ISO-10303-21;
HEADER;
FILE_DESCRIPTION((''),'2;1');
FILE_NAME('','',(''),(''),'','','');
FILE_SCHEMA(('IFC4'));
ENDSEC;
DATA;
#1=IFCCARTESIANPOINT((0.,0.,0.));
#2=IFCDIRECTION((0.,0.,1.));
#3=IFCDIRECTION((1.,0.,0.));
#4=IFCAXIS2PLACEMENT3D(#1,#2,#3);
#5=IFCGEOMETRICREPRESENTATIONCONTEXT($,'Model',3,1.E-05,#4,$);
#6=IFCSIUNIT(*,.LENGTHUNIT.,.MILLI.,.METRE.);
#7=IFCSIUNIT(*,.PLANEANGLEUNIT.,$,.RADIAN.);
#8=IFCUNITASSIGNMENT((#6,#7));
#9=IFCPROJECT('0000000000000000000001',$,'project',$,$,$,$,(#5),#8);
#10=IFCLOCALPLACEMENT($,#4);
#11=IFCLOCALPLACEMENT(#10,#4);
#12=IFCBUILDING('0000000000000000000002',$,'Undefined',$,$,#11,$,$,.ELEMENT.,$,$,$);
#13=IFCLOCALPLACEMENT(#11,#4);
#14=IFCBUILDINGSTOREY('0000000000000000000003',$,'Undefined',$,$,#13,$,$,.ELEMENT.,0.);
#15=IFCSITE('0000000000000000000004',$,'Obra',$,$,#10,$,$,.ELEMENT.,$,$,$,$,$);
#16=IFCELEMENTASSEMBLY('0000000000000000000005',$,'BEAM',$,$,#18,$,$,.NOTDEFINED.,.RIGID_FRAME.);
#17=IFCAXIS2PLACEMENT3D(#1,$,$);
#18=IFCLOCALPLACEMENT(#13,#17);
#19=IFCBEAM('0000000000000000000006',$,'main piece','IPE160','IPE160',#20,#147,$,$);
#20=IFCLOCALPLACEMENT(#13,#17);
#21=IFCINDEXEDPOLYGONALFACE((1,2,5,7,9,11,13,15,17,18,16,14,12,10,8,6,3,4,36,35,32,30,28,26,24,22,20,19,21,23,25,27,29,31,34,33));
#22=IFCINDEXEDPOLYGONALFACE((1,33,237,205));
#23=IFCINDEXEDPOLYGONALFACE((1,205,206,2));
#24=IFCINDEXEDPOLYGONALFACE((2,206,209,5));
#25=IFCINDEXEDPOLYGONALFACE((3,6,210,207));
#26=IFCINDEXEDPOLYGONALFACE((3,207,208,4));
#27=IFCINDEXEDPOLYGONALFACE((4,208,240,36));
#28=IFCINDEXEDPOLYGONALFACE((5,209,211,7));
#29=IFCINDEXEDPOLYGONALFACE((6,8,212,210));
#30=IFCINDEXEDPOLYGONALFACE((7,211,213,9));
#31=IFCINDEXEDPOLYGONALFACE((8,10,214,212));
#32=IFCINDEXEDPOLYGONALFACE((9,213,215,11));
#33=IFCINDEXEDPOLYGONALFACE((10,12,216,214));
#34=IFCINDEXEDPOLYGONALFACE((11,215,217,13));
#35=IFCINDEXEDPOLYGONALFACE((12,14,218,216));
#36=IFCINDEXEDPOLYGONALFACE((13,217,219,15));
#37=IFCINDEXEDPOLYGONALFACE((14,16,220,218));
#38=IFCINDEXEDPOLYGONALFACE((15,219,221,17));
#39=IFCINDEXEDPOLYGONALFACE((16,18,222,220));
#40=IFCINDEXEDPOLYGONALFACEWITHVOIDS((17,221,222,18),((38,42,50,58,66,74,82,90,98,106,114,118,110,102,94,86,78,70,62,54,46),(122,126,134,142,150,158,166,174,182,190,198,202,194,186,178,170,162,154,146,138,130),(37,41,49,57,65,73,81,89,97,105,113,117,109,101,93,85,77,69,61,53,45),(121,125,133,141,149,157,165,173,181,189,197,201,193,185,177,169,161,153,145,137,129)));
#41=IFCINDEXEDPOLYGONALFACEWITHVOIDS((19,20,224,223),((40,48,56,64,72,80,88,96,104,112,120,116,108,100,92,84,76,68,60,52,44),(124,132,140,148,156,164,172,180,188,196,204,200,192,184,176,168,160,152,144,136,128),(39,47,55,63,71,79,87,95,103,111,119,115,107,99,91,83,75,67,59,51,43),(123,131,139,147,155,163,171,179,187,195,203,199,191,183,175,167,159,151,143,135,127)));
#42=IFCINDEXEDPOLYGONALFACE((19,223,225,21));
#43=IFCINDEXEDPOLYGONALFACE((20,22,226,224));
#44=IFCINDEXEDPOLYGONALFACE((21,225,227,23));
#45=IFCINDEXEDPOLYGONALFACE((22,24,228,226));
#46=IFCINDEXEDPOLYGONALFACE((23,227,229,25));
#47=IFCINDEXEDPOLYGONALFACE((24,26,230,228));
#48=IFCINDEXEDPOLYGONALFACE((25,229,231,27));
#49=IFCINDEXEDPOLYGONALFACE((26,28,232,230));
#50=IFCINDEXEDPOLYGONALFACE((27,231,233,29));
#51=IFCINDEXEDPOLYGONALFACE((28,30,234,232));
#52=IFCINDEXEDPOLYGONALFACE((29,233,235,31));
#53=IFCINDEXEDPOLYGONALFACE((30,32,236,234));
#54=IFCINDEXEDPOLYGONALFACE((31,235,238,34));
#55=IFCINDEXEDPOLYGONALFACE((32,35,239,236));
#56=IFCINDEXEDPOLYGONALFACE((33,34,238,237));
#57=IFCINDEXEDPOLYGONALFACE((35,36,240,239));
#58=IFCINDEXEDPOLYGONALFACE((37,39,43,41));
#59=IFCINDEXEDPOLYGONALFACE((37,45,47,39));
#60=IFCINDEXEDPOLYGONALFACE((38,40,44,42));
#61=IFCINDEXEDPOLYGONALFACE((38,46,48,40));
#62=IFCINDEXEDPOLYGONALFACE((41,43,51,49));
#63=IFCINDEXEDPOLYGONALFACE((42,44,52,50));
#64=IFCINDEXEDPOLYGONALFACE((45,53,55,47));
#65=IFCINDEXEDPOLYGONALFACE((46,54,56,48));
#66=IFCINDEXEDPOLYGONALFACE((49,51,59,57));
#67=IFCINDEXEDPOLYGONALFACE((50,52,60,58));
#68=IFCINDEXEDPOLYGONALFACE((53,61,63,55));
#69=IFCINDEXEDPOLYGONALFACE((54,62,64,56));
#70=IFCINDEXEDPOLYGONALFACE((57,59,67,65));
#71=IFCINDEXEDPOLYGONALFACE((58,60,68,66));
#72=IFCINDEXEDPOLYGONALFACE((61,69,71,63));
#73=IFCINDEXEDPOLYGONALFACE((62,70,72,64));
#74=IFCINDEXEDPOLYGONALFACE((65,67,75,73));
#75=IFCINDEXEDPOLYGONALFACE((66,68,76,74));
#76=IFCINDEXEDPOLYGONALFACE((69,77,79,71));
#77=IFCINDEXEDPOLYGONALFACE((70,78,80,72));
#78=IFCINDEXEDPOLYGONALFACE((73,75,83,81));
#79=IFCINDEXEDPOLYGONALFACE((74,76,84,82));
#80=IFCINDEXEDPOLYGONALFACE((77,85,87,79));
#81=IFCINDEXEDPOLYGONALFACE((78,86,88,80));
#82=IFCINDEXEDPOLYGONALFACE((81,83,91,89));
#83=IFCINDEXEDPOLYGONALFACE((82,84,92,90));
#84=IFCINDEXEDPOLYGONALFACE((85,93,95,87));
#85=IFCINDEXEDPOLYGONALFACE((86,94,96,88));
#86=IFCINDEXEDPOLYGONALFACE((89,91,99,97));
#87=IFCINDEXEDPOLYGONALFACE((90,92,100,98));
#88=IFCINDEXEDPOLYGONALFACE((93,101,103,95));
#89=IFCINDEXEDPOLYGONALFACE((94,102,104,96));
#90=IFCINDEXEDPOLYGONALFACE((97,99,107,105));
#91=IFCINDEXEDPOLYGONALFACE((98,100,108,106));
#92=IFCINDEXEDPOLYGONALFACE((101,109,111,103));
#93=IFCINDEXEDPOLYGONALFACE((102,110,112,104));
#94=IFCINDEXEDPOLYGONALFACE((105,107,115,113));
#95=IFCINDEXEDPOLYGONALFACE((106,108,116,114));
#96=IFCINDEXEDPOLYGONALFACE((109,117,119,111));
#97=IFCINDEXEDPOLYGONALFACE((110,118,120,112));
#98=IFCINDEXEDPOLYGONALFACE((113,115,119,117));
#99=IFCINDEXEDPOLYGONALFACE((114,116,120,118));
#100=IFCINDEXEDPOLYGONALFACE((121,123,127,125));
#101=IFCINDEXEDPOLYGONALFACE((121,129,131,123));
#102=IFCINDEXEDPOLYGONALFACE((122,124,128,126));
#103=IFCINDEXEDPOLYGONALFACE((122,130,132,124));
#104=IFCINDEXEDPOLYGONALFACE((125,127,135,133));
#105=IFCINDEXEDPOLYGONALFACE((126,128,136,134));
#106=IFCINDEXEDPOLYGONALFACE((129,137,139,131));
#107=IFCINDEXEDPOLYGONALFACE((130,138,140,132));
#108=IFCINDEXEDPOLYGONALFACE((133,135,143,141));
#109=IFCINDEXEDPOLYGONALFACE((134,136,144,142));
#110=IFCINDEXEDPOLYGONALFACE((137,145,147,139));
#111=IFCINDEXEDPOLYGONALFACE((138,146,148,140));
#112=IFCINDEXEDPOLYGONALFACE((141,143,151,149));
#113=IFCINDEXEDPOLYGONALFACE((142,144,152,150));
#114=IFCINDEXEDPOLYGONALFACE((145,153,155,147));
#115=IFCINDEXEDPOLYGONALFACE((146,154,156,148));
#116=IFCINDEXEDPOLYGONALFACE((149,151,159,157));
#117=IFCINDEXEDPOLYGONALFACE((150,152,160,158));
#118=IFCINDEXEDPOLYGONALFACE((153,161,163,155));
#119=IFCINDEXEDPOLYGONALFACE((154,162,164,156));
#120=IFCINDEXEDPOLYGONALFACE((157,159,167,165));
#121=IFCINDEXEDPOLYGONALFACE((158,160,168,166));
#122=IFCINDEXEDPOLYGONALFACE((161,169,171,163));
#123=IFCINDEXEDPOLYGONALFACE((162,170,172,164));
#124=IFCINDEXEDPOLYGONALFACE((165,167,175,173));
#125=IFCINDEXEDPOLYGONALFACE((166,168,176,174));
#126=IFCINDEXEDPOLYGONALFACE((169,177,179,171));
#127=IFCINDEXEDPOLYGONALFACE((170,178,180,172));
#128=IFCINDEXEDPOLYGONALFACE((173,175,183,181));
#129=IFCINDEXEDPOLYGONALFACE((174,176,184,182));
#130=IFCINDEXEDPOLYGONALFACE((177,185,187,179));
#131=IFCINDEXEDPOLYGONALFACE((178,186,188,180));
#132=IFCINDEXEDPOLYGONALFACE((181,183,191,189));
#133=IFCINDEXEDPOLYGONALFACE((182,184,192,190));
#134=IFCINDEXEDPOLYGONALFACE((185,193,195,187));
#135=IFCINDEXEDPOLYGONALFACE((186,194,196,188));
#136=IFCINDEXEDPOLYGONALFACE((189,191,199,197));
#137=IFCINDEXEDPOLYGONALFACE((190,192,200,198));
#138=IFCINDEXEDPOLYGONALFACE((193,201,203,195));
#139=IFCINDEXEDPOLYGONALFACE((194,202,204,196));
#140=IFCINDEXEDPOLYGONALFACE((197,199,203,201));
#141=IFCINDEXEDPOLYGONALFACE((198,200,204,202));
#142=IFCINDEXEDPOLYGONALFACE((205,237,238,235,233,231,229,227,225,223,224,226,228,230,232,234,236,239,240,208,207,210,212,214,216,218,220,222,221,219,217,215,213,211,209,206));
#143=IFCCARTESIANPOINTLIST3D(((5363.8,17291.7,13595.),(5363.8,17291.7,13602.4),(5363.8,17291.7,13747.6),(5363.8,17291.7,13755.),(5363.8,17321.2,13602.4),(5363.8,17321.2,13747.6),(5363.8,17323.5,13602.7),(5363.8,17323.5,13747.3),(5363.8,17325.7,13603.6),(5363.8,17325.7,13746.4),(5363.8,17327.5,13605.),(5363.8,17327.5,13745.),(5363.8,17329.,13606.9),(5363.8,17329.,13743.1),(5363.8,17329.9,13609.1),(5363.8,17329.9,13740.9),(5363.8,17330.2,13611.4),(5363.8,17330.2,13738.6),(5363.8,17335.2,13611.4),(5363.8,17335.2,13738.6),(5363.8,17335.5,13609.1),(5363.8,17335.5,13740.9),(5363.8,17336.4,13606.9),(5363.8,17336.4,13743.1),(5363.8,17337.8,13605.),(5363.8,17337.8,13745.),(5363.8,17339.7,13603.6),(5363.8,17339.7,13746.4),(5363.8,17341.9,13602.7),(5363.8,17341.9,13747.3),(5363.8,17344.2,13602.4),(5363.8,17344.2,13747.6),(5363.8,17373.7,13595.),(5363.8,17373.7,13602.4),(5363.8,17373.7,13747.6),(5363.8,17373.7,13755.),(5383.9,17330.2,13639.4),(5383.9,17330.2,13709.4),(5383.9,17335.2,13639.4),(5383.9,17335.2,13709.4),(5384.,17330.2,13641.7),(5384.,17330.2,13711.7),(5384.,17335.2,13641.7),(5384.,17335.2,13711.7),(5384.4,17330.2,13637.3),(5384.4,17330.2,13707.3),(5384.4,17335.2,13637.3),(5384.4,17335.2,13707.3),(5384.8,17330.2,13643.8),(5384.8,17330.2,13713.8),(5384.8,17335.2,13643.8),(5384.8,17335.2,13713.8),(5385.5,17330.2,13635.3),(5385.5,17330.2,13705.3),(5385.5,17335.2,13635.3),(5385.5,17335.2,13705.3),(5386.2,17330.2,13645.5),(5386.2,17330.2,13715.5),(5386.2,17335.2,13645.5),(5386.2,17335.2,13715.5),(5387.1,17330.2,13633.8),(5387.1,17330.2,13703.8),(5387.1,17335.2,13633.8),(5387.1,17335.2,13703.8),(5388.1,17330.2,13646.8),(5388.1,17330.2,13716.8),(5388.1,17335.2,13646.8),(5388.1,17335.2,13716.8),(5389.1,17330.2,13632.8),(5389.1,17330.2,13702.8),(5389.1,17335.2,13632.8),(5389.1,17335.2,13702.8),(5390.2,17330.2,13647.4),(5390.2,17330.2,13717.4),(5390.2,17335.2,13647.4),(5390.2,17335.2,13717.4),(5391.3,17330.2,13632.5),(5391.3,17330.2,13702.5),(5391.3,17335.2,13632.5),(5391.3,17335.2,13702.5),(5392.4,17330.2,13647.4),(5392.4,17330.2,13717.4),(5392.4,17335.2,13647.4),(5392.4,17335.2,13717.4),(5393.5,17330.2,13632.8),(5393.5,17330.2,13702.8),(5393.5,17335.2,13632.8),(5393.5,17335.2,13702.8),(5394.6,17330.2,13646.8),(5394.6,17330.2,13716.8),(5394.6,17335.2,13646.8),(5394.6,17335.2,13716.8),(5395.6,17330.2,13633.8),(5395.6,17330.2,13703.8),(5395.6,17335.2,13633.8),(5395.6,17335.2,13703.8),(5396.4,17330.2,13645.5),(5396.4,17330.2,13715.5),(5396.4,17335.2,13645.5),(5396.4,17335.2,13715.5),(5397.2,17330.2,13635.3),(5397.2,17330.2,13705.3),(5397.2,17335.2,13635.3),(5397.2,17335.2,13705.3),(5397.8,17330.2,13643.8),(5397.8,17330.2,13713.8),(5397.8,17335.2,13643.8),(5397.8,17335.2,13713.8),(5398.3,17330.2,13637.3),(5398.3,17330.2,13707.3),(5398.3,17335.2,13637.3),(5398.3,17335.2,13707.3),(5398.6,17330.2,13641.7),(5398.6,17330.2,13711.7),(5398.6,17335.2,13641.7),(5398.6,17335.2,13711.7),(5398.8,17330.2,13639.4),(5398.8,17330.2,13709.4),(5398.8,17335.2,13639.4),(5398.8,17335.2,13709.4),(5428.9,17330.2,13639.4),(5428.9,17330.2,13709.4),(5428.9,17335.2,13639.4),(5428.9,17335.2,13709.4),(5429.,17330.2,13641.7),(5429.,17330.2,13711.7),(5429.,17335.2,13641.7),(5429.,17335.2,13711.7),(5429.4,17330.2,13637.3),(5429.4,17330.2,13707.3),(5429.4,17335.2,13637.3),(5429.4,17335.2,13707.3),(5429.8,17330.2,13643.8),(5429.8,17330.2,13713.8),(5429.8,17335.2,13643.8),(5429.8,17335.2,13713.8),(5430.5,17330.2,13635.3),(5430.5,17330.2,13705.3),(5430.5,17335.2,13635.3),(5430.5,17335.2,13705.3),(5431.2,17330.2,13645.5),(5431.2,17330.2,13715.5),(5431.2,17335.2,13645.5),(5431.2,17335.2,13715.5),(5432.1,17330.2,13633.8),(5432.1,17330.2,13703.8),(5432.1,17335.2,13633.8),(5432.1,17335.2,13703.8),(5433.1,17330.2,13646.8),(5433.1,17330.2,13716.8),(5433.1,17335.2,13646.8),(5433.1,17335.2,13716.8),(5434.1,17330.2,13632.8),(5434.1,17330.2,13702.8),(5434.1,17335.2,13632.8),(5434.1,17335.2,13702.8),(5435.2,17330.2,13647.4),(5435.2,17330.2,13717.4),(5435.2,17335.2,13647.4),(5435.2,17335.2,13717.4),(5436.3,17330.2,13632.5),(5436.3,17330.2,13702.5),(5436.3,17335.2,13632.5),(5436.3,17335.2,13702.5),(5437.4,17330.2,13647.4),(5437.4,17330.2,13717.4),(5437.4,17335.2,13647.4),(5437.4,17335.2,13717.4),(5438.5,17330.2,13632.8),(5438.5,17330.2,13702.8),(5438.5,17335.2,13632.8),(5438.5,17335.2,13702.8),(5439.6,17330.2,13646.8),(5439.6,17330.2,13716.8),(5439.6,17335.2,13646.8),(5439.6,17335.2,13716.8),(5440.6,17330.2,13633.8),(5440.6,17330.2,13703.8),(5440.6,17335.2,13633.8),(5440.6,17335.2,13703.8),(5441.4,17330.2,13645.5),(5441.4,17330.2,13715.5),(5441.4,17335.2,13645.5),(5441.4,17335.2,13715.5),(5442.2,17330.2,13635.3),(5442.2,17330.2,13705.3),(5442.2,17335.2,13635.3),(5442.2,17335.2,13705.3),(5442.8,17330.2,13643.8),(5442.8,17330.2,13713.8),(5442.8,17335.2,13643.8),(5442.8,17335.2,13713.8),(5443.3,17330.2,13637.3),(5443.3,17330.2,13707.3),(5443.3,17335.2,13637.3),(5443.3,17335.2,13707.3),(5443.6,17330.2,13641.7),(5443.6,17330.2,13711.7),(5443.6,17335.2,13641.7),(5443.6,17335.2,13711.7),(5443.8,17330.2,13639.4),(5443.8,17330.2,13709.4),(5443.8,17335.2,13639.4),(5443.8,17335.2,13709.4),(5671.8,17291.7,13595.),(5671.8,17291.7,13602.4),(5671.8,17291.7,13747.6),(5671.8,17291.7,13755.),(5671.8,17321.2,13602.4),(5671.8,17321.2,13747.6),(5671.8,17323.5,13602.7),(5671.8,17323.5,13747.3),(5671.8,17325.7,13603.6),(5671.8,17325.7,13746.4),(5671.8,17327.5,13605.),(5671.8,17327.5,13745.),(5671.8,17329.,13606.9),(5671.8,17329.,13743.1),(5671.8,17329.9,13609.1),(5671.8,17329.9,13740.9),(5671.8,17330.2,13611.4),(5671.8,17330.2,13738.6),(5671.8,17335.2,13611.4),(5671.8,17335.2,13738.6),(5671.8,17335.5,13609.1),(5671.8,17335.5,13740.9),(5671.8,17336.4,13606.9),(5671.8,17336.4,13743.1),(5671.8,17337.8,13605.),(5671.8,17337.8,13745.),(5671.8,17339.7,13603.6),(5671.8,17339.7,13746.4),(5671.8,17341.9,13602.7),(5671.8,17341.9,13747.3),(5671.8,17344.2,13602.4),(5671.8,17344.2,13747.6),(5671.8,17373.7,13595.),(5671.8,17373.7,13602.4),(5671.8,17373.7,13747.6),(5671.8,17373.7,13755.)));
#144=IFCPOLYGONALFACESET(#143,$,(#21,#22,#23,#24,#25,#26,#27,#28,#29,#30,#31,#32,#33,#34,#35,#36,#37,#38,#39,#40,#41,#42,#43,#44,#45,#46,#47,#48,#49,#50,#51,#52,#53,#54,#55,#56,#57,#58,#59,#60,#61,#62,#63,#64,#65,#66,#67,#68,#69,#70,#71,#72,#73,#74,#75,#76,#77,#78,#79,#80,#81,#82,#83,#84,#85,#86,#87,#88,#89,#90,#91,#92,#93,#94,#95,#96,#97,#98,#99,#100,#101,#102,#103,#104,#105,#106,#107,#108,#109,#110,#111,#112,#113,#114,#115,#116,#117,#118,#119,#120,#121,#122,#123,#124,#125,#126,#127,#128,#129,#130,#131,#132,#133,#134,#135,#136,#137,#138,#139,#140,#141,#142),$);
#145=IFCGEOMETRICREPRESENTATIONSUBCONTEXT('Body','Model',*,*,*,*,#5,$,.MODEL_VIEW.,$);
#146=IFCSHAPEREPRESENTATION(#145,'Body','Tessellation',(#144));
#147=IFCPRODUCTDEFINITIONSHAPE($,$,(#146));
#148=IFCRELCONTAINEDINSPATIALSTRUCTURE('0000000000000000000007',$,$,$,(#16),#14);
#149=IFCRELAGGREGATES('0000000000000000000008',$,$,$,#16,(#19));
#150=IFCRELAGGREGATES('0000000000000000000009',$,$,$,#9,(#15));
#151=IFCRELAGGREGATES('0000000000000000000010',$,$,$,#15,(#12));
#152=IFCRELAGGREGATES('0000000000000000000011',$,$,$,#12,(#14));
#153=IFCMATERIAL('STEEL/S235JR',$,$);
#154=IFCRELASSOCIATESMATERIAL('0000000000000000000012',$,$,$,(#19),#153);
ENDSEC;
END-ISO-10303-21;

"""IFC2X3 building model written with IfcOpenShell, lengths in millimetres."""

from ifc_helpers import new_model, si_unit, frame, origin_with_axes, origin_2d_with_axis, place, context, subcontext, project, spatial, circle, i_section, extrude, clip, halfspace, source, transform, mapped, material, element, aggregate, save


model = new_model("IFC2X3")

# Units and contexts
model_context = context("Model", 3, precision=1e-05, world=origin_with_axes())
body_context = subcontext(model_context, "Body", "Model", "MODEL_VIEW")
ifc_project = project(units=[si_unit("LENGTHUNIT", "METRE", prefix="MILLI"), si_unit("PLANEANGLEUNIT", "RADIAN")], contexts=[model_context])

# Site, building, storey
site_placement = place(None, origin_with_axes())
site = spatial("IfcSite", under=ifc_project, at=site_placement, Name="Obra", CompositionType="ELEMENT")
building_placement = place(site_placement, origin_with_axes())
building = spatial("IfcBuilding", under=site, at=building_placement, Name="Undefined", CompositionType="ELEMENT")
storey_placement = place(building_placement, origin_with_axes())
storey = spatial("IfcBuildingStorey", under=building, at=storey_placement, Name="Undefined", CompositionType="ELEMENT", Elevation=0.0)

# Shared definitions
ifc_material_1 = material(Name="STEEL/S235JR")

# Element assembly, beam, opening
assembly_1_placement = place(storey_placement, origin_with_axes())
assembly_1 = element("IfcElementAssembly", 1, at=assembly_1_placement, inside=storey, Name="BEAM", AssemblyPlace="NOTDEFINED", PredefinedType="RIGID_FRAME")
beam_1_placement = place(assembly_1_placement, frame((5373.8, 17332.7, 13675.0), z_axis=(0.0, 0.0, 1.0), x_axis=(1.0, -0.000004, 0.0)))
beam_1 = element("IfcBeam", 2, at=beam_1_placement, material=ifc_material_1, Name="main piece", Description="IPE160", ObjectType="IPE160", context=body_context, shape_type="Clipping", body=[
    clip(extrude(i_section(OverallWidth=82.0, OverallDepth=160.0, WebThickness=5.0, FlangeThickness=7.4, FilletRadius=9.0, at=origin_2d_with_axis()), frame((298.0, 0.0, 0.0), z_axis=(-1.0, 0.0, 0.0), x_axis=(0.0, -1.0, 0.0)), (0.0, 0.0, 1.0), 308.0), halfspace(frame((-10.0, 0.0, -180.0), z_axis=(1.0, 0.000004, 0.0), x_axis=(0.000004, -1.0, 0.0)), True)),
])
shared_shape_1 = source(origin_with_axes(), body_context, "Body", "SweptSolid", [
    extrude(circle(Radius=7.5, at=origin_2d_with_axis()), frame((0.0, -2.6, 0.0), z_axis=(0.0, 1.0, 0.0), x_axis=(1.0, 0.0, 0.0)), (0.0, 0.0, 1.0), 5.2),
])
opening_1_placement = place(assembly_1_placement, frame((5413.8, 17332.7, 13710.0), z_axis=(1.0, 0.0, 0.0), x_axis=(0.0, 0.0, -1.0)))
element("IfcOpeningElement", 3, at=opening_1_placement, cuts=beam_1, ObjectType="Opening", context=body_context, shape_type="MappedRepresentation", body=[
    mapped(shared_shape_1, transform((0.0, 0.0, -22.5))),
    mapped(shared_shape_1, transform((70.0, 0.0, -22.5))),
    mapped(shared_shape_1, transform((0.0, 0.0, 22.5))),
    mapped(shared_shape_1, transform((70.0, 0.0, 22.5))),
])

aggregate(assembly_1, [beam_1])

save(model, "model.ifc")
